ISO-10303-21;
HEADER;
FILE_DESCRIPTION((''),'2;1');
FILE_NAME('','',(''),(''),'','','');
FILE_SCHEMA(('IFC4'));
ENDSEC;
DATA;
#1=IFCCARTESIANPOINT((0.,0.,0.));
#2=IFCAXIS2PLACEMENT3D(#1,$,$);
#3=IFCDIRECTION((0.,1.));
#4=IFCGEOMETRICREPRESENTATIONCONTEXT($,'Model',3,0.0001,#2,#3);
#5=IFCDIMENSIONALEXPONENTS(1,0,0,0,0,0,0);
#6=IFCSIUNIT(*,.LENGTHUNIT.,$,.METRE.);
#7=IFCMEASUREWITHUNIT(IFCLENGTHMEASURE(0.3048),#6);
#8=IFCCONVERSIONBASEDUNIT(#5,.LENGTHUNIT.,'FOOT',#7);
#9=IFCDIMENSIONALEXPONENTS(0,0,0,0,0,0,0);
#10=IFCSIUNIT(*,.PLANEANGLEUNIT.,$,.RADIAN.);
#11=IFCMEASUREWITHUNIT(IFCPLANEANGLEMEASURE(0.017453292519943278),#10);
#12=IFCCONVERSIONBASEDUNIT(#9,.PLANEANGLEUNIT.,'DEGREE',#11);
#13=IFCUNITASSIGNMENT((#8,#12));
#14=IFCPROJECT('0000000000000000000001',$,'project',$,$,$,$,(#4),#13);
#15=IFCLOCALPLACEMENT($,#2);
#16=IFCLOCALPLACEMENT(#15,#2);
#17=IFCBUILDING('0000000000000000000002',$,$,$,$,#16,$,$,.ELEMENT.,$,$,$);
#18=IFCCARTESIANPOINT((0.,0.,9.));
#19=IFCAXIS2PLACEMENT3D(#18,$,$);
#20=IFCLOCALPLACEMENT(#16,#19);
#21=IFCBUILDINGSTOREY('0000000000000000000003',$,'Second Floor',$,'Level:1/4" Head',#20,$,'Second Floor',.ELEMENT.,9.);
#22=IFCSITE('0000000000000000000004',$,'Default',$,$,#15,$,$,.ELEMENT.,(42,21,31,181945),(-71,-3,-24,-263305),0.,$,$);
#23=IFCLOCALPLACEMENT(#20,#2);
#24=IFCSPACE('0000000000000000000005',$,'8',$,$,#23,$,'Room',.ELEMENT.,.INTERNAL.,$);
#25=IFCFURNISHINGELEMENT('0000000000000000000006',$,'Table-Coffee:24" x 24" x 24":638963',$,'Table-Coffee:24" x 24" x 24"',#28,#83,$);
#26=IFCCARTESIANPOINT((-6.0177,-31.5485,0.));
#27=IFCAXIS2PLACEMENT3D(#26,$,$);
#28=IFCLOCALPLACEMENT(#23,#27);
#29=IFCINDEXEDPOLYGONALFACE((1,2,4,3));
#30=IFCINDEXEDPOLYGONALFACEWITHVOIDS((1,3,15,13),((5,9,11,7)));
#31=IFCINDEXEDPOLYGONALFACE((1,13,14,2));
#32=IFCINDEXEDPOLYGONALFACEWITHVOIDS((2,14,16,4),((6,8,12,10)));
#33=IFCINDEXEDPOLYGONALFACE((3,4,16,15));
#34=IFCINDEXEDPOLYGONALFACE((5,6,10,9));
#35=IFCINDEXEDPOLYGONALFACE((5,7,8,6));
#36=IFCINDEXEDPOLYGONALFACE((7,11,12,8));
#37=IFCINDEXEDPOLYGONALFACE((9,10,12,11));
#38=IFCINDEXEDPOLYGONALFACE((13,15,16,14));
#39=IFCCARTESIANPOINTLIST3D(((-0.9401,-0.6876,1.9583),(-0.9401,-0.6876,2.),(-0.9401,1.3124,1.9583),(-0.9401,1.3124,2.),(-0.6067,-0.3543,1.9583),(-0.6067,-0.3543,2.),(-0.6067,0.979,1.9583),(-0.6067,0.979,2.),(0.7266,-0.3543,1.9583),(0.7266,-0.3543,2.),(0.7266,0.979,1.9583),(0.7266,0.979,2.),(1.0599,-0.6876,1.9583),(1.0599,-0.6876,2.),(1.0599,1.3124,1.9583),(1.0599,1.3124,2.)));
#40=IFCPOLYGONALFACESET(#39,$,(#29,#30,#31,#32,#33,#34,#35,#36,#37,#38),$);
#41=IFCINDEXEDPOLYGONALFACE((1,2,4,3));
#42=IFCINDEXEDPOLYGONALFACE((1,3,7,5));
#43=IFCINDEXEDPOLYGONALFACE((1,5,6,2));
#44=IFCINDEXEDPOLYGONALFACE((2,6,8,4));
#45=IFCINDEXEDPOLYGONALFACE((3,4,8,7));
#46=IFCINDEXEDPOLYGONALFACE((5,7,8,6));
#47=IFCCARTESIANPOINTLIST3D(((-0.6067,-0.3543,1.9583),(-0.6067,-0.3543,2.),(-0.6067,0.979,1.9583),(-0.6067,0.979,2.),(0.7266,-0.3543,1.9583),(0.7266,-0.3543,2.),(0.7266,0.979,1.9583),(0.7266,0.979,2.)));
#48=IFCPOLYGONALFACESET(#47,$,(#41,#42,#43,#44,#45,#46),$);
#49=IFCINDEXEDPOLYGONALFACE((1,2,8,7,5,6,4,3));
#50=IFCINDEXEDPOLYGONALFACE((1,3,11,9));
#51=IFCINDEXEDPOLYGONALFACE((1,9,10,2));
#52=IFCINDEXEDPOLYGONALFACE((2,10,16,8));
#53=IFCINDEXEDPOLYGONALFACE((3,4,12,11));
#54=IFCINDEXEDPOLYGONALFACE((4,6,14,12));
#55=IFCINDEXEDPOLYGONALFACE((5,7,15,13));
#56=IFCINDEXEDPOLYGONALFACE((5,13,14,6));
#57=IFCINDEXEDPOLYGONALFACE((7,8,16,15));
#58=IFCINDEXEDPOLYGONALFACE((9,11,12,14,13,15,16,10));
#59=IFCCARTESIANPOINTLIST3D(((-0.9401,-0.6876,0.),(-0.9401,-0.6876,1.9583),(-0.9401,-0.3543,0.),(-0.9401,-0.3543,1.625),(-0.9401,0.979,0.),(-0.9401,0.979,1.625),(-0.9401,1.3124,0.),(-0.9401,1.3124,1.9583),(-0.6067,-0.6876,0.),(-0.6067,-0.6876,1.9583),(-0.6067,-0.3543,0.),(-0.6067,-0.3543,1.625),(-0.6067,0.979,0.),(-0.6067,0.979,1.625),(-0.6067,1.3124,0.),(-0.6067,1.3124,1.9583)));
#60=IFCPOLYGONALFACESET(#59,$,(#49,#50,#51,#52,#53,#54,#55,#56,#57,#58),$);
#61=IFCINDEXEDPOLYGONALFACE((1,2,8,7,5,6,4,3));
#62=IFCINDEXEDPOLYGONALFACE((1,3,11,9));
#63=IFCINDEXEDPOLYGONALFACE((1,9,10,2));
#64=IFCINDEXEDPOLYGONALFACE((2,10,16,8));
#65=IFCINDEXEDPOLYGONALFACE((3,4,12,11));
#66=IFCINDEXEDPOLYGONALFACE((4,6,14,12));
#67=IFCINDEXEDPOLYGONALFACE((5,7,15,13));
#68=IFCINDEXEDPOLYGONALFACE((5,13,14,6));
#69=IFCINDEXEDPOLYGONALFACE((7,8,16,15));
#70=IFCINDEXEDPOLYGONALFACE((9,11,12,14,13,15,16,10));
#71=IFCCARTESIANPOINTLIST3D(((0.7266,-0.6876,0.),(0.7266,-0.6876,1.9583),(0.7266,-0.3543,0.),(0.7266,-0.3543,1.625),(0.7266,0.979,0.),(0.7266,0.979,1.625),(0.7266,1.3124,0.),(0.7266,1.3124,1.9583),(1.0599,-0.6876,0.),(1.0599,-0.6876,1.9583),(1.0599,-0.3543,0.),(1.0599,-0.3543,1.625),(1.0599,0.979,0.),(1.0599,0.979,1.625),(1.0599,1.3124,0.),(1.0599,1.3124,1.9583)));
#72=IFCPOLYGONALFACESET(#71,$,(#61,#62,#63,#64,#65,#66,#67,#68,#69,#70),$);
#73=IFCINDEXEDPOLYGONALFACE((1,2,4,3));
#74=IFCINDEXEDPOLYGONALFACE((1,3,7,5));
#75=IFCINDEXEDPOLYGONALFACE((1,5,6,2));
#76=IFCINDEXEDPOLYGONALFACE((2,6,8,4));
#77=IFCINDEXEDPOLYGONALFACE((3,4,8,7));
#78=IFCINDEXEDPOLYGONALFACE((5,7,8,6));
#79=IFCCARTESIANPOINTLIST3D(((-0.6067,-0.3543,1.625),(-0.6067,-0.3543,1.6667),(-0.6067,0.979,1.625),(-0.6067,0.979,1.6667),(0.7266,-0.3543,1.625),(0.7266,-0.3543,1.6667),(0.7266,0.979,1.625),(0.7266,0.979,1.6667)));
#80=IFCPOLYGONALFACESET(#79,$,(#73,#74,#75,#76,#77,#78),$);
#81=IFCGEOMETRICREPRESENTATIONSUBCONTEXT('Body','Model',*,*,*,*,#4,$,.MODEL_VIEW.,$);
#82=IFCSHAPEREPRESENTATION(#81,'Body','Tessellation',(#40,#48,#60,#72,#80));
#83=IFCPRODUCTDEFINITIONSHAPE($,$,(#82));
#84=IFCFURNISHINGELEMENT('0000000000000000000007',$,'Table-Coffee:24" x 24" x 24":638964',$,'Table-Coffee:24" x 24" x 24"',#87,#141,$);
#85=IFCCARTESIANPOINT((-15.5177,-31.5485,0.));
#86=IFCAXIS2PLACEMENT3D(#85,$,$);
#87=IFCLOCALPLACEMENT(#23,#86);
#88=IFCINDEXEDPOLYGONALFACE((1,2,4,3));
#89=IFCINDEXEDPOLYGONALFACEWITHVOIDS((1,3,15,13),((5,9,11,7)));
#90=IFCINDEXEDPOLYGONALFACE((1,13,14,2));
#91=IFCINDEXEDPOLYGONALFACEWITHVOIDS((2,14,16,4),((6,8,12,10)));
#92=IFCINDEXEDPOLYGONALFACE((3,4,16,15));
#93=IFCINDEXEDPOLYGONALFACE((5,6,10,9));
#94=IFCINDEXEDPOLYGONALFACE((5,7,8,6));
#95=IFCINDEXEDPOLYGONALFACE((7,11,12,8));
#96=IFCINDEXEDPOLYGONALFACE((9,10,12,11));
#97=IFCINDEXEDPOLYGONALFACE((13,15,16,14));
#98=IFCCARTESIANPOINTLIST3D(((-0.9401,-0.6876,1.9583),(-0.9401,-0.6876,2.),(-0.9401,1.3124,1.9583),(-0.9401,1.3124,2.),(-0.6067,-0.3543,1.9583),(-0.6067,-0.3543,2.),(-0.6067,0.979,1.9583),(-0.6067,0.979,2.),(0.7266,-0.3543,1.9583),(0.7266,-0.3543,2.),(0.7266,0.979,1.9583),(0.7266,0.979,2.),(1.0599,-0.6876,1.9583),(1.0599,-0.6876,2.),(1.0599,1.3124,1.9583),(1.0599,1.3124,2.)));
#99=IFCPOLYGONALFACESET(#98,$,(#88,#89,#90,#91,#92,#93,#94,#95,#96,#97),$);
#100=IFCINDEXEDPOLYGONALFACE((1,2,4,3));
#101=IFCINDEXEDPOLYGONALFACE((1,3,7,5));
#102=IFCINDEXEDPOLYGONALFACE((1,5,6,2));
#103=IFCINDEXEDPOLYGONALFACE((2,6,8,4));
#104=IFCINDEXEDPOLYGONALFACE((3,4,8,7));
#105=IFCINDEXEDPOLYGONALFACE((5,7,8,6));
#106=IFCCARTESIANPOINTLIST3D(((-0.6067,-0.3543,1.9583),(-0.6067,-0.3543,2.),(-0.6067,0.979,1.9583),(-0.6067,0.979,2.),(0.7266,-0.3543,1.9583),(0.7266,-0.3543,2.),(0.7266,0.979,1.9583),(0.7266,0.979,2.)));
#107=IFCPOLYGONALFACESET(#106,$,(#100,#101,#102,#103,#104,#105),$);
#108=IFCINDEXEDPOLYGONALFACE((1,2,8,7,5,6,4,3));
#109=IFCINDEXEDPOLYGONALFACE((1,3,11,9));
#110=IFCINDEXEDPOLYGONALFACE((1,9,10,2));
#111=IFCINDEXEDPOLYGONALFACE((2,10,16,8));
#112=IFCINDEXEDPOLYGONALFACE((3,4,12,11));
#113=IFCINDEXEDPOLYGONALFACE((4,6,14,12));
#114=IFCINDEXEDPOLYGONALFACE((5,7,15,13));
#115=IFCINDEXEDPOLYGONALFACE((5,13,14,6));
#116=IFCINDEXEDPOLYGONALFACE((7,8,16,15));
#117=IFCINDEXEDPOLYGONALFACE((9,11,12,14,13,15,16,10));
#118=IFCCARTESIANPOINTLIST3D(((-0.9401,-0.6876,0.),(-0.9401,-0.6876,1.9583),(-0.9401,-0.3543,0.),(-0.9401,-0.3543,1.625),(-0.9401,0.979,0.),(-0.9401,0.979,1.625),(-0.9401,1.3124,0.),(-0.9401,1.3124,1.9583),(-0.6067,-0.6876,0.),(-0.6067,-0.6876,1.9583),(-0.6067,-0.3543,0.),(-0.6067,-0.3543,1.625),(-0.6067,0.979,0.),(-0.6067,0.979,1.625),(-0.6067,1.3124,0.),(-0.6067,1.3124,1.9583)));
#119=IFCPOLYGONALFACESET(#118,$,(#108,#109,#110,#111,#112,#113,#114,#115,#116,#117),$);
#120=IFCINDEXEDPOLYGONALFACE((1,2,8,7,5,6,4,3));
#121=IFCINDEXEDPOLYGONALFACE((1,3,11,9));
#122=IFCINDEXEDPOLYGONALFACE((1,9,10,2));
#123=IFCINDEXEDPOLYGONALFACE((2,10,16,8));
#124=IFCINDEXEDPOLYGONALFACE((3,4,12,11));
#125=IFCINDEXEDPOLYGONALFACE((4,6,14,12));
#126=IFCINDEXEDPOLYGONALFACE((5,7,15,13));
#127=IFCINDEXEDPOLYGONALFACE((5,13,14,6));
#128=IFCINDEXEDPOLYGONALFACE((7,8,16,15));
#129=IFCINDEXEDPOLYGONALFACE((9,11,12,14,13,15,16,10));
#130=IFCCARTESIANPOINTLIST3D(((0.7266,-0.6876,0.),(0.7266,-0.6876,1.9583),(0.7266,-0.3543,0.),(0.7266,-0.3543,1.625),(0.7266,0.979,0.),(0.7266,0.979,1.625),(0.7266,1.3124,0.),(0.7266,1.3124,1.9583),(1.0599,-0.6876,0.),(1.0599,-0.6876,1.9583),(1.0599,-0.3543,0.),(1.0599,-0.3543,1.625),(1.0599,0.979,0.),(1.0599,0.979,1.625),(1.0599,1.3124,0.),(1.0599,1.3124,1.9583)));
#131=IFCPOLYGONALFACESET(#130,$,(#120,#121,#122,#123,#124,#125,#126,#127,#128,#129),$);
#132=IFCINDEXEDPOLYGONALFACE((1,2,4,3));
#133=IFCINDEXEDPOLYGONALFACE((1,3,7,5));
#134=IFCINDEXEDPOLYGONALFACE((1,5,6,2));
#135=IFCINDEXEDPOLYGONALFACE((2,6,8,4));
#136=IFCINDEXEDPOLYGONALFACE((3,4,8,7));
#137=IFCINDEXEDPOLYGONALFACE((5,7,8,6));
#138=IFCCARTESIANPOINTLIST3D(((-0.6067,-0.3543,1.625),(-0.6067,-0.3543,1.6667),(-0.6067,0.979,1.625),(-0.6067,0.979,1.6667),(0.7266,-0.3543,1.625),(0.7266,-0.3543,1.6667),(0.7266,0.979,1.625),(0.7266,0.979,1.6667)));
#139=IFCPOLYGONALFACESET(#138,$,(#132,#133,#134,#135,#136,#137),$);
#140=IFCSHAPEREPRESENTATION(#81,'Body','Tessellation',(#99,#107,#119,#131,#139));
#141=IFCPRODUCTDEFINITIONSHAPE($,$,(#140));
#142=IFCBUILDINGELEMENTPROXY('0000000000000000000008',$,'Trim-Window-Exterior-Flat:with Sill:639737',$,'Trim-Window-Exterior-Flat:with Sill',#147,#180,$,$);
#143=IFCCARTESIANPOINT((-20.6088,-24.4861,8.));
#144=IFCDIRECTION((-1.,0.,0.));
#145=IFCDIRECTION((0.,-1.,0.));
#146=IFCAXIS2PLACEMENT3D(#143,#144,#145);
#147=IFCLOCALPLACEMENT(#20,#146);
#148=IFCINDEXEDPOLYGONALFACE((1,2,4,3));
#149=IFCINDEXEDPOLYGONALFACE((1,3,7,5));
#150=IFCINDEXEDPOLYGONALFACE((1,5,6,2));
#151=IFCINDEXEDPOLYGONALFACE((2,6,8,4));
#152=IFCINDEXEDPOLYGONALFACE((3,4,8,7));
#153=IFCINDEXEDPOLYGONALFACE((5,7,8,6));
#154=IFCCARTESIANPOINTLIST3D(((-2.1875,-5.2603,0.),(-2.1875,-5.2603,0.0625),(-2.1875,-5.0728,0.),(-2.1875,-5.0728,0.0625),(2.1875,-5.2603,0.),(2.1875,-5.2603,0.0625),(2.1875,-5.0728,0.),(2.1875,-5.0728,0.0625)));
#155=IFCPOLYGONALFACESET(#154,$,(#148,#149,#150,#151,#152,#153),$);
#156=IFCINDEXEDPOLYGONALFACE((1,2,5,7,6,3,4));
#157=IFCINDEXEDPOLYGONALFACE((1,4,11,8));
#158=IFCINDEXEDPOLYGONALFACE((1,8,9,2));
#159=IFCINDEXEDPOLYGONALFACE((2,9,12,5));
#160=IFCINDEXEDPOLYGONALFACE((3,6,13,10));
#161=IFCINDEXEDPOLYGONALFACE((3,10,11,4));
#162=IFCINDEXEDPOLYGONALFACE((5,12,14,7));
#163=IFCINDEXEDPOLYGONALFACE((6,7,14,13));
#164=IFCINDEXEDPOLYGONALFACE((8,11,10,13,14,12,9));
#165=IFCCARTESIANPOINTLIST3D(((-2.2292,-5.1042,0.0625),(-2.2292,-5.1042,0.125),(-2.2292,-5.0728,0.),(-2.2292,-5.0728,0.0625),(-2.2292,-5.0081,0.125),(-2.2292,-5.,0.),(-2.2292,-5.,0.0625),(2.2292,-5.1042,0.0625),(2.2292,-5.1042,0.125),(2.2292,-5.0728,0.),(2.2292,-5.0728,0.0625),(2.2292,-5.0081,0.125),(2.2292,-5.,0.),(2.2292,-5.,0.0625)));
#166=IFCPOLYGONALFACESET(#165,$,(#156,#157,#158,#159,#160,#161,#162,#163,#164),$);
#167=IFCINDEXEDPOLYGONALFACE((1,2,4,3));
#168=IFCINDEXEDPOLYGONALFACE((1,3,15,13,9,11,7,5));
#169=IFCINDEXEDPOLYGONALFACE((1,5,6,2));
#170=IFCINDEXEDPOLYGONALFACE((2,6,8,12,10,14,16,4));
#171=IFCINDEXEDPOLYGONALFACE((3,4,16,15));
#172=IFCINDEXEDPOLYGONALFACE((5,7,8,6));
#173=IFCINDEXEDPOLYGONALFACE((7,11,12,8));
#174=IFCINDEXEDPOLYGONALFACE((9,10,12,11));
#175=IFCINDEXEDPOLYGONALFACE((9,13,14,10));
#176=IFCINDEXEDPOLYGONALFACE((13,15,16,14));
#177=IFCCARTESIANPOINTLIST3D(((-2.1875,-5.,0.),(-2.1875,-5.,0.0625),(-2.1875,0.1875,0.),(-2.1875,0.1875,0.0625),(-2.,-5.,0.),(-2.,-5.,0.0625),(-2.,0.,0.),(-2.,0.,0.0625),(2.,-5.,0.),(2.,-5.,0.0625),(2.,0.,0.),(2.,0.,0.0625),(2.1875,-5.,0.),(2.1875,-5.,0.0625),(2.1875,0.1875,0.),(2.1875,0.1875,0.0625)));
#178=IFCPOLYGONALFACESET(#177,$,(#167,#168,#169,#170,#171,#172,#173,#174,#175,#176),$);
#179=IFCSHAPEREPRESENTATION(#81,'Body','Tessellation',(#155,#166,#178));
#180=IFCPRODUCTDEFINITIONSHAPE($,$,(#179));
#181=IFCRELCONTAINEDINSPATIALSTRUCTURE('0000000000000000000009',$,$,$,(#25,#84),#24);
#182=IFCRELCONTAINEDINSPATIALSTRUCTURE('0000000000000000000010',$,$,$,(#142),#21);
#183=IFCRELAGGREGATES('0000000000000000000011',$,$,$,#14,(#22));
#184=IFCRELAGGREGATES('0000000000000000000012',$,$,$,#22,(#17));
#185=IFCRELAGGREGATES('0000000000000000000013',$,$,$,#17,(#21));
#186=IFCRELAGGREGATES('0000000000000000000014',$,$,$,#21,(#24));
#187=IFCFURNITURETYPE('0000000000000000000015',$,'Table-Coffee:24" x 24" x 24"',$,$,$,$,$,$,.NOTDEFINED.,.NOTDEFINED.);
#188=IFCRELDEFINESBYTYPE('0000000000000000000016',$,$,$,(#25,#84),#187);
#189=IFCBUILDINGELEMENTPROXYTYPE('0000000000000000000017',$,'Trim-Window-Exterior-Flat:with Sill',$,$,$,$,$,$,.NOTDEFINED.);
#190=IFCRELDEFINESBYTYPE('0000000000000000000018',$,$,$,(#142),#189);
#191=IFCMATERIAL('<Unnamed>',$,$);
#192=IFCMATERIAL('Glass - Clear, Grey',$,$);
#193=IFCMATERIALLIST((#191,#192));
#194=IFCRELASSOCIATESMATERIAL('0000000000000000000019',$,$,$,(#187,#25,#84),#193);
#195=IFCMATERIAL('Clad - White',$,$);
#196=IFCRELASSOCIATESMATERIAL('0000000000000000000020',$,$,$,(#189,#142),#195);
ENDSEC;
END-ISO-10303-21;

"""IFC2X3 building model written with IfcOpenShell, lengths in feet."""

from ifc_helpers import new_model, entity, si_unit, converted_unit, direction, frame, frame_2d, origin, origin_2d_with_axis, place, context, subcontext, project, spatial, polyline, rectangle, outline, extrude, source, transform, mapped, material, material_list, type_object, type_shapes, element, save


model = new_model("IFC2X3")

# Units and contexts
model_context = context("Model", 3, precision=0.0001, world=origin(), true_north=direction((0.0, 1.0)))
body_context = subcontext(model_context, "Body", "Model", "MODEL_VIEW")
ifc_project = project(units=[converted_unit("LENGTHUNIT", "FOOT", entity("IfcLengthMeasure", 0.3048), si_unit("LENGTHUNIT", "METRE"), dimensions=[1, 0, 0, 0, 0, 0, 0]), converted_unit("PLANEANGLEUNIT", "DEGREE", entity("IfcPlaneAngleMeasure", 0.017453292519943278), si_unit("PLANEANGLEUNIT", "RADIAN"), dimensions=[0, 0, 0, 0, 0, 0, 0])], contexts=[model_context])

# Site, building, storey
site_placement = place(None, origin())
site = spatial("IfcSite", under=ifc_project, at=site_placement, Name="Default", CompositionType="ELEMENT", RefLatitude=(42, 21, 31, 181945), RefLongitude=(-71, -3, -24, -263305), RefElevation=0.0)
building_placement = place(site_placement, origin())
building = spatial("IfcBuilding", under=site, at=building_placement, CompositionType="ELEMENT")
storey_placement = place(building_placement, frame((0.0, 0.0, 9.0)))
storey = spatial("IfcBuildingStorey", under=building, at=storey_placement, Name="Second Floor", ObjectType="Level:1/4\" Head", LongName="Second Floor", CompositionType="ELEMENT", Elevation=9.0)

# Shared definitions
space_placement = place(storey_placement, origin())
space = spatial("IfcSpace", under=storey, at=space_placement, Name="8", LongName="Room", CompositionType="ELEMENT", InteriorOrExteriorSpace="INTERNAL")

# Furnishing elements
ifc_material_1 = material(Name="<Unnamed>")
ifc_material_2 = material(Name="Glass - Clear, Grey")
ifc_material_list_1 = material_list([ifc_material_1, ifc_material_2])
furniture_type_1 = type_object("IfcFurnitureType", Name="Table-Coffee:24\" x 24\" x 24\"", AssemblyPlace="NOTDEFINED", material=ifc_material_list_1)
shared_shape_1 = source(origin(), body_context, "Body", "SweptSolid", [
    extrude(outline(polyline([(-1.0, -1.0), (1.0, -1.0), (1.0, 1.0), (-1.0, 1.0), (-1.0, -1.0)]), holes=[polyline([(-0.6667, -0.6667), (-0.6667, 0.6667), (0.6667, 0.6667), (0.6667, -0.6667), (-0.6667, -0.6667)])]), frame((0.0599, 0.3124, 1.9583), z_axis=(0.0, 0.0, 1.0), x_axis=(-1.0, 0.0, 0.0)), (0.0, 0.0, 1.0), 0.0417),
    extrude(rectangle(XDim=1.3333, YDim=1.3333, at=origin_2d_with_axis()), frame((0.0599, 0.3124, 1.9583), z_axis=(0.0, 0.0, 1.0), x_axis=(-1.0, 0.0, 0.0)), (0.0, 0.0, 1.0), 0.0417),
    extrude(outline(polyline([(-1.0, -1.0625), (1.0, -1.0625), (1.0, 0.8958), (0.6667, 0.8958), (0.6667, -0.7292), (-0.6667, -0.7292), (-0.6667, 0.8958), (-1.0, 0.8958), (-1.0, -1.0625)])), frame((-0.9401, 0.3124, 0.8958), z_axis=(1.0, 0.0, 0.0), x_axis=(0.0, -1.0, 0.0)), (0.0, 0.0, 1.0), 0.3333),
    extrude(outline(polyline([(-0.8958, -1.0), (1.0625, -1.0), (1.0625, 1.0), (-0.8958, 1.0), (-0.8958, 0.6667), (0.7292, 0.6667), (0.7292, -0.6667), (-0.8958, -0.6667), (-0.8958, -1.0)])), frame((0.7266, 0.3124, 0.8958), z_axis=(1.0, 0.0, 0.0), x_axis=(0.0, 0.0, 1.0)), (0.0, 0.0, 1.0), 0.3333),
    extrude(rectangle(XDim=1.3333, YDim=1.3333, at=origin_2d_with_axis()), frame((0.0599, 0.3124, 1.625), z_axis=(0.0, 0.0, 1.0), x_axis=(-1.0, 0.0, 0.0)), (0.0, 0.0, 1.0), 0.0417),
])
type_shapes(furniture_type_1, [shared_shape_1])
for number, where, name in (
    (1, (-6.0177, -31.5485, 0.0), "Table-Coffee:24\" x 24\" x 24\":638963"),
    (2, (-15.5177, -31.5485, 0.0), "Table-Coffee:24\" x 24\" x 24\":638964"),
):
    element("IfcFurnishingElement", number, at=place(space_placement, frame(where)), inside=space, type_object=furniture_type_1, material=ifc_material_list_1, Name=name, ObjectType="Table-Coffee:24\" x 24\" x 24\"", context=body_context, shape_type="MappedRepresentation", body=[
        mapped(shared_shape_1, transform((0.0, 0.0, 0.0), scale=1.0)),
    ])

# Building element proxy
ifc_material_3 = material(Name="Clad - White")
building_element_proxy_type_1 = type_object("IfcBuildingElementProxyType", Name="Trim-Window-Exterior-Flat:with Sill", PredefinedType="NOTDEFINED", material=ifc_material_3)
shared_shape_2 = source(origin(), body_context, "Body", "SweptSolid", [
    extrude(rectangle(XDim=4.375, YDim=0.1875, at=frame_2d((0.0, 0.0), x_axis=(1.0, 0.0))), frame((0.0, -5.1665, 0.0), z_axis=(0.0, 0.0, 1.0), x_axis=(-1.0, 0.0, 0.0)), (0.0, 0.0, 1.0), 0.0625),
    extrude(outline(polyline([(-0.0625, -0.0525), (0.0, -0.0525), (0.0, -0.0211), (0.0625, -0.0211), (0.0625, 0.0517), (0.0, 0.0517), (-0.0625, 0.0436), (-0.0625, -0.0525)])), frame((-2.2292, -5.0517, 0.0625), z_axis=(1.0, 0.0, 0.0), x_axis=(0.0, 0.0, -1.0)), (0.0, 0.0, 1.0), 4.4583),
    extrude(outline(polyline([(-2.6406, -2.1875), (2.5469, -2.1875), (2.5469, -2.0), (-2.4531, -2.0), (-2.4531, 2.0), (2.5469, 2.0), (2.5469, 2.1875), (-2.6406, 2.1875), (-2.6406, -2.1875)])), frame((0.0, -2.4531, 0.0), z_axis=(0.0, 0.0, 1.0), x_axis=(0.0, -1.0, 0.0)), (0.0, 0.0, 1.0), 0.0625),
])
type_shapes(building_element_proxy_type_1, [shared_shape_2])
proxy_1_placement = place(storey_placement, frame((-20.6088, -24.4861, 8.0), z_axis=(-1.0, 0.0, 0.0), x_axis=(0.0, -1.0, 0.0)))
element("IfcBuildingElementProxy", 3, at=proxy_1_placement, inside=storey, type_object=building_element_proxy_type_1, material=ifc_material_3, Name="Trim-Window-Exterior-Flat:with Sill:639737", ObjectType="Trim-Window-Exterior-Flat:with Sill", context=body_context, shape_type="MappedRepresentation", body=[
    mapped(shared_shape_2, transform((0.0, 0.0, 0.0), scale=1.0)),
])

save(model, "model.ifc")
